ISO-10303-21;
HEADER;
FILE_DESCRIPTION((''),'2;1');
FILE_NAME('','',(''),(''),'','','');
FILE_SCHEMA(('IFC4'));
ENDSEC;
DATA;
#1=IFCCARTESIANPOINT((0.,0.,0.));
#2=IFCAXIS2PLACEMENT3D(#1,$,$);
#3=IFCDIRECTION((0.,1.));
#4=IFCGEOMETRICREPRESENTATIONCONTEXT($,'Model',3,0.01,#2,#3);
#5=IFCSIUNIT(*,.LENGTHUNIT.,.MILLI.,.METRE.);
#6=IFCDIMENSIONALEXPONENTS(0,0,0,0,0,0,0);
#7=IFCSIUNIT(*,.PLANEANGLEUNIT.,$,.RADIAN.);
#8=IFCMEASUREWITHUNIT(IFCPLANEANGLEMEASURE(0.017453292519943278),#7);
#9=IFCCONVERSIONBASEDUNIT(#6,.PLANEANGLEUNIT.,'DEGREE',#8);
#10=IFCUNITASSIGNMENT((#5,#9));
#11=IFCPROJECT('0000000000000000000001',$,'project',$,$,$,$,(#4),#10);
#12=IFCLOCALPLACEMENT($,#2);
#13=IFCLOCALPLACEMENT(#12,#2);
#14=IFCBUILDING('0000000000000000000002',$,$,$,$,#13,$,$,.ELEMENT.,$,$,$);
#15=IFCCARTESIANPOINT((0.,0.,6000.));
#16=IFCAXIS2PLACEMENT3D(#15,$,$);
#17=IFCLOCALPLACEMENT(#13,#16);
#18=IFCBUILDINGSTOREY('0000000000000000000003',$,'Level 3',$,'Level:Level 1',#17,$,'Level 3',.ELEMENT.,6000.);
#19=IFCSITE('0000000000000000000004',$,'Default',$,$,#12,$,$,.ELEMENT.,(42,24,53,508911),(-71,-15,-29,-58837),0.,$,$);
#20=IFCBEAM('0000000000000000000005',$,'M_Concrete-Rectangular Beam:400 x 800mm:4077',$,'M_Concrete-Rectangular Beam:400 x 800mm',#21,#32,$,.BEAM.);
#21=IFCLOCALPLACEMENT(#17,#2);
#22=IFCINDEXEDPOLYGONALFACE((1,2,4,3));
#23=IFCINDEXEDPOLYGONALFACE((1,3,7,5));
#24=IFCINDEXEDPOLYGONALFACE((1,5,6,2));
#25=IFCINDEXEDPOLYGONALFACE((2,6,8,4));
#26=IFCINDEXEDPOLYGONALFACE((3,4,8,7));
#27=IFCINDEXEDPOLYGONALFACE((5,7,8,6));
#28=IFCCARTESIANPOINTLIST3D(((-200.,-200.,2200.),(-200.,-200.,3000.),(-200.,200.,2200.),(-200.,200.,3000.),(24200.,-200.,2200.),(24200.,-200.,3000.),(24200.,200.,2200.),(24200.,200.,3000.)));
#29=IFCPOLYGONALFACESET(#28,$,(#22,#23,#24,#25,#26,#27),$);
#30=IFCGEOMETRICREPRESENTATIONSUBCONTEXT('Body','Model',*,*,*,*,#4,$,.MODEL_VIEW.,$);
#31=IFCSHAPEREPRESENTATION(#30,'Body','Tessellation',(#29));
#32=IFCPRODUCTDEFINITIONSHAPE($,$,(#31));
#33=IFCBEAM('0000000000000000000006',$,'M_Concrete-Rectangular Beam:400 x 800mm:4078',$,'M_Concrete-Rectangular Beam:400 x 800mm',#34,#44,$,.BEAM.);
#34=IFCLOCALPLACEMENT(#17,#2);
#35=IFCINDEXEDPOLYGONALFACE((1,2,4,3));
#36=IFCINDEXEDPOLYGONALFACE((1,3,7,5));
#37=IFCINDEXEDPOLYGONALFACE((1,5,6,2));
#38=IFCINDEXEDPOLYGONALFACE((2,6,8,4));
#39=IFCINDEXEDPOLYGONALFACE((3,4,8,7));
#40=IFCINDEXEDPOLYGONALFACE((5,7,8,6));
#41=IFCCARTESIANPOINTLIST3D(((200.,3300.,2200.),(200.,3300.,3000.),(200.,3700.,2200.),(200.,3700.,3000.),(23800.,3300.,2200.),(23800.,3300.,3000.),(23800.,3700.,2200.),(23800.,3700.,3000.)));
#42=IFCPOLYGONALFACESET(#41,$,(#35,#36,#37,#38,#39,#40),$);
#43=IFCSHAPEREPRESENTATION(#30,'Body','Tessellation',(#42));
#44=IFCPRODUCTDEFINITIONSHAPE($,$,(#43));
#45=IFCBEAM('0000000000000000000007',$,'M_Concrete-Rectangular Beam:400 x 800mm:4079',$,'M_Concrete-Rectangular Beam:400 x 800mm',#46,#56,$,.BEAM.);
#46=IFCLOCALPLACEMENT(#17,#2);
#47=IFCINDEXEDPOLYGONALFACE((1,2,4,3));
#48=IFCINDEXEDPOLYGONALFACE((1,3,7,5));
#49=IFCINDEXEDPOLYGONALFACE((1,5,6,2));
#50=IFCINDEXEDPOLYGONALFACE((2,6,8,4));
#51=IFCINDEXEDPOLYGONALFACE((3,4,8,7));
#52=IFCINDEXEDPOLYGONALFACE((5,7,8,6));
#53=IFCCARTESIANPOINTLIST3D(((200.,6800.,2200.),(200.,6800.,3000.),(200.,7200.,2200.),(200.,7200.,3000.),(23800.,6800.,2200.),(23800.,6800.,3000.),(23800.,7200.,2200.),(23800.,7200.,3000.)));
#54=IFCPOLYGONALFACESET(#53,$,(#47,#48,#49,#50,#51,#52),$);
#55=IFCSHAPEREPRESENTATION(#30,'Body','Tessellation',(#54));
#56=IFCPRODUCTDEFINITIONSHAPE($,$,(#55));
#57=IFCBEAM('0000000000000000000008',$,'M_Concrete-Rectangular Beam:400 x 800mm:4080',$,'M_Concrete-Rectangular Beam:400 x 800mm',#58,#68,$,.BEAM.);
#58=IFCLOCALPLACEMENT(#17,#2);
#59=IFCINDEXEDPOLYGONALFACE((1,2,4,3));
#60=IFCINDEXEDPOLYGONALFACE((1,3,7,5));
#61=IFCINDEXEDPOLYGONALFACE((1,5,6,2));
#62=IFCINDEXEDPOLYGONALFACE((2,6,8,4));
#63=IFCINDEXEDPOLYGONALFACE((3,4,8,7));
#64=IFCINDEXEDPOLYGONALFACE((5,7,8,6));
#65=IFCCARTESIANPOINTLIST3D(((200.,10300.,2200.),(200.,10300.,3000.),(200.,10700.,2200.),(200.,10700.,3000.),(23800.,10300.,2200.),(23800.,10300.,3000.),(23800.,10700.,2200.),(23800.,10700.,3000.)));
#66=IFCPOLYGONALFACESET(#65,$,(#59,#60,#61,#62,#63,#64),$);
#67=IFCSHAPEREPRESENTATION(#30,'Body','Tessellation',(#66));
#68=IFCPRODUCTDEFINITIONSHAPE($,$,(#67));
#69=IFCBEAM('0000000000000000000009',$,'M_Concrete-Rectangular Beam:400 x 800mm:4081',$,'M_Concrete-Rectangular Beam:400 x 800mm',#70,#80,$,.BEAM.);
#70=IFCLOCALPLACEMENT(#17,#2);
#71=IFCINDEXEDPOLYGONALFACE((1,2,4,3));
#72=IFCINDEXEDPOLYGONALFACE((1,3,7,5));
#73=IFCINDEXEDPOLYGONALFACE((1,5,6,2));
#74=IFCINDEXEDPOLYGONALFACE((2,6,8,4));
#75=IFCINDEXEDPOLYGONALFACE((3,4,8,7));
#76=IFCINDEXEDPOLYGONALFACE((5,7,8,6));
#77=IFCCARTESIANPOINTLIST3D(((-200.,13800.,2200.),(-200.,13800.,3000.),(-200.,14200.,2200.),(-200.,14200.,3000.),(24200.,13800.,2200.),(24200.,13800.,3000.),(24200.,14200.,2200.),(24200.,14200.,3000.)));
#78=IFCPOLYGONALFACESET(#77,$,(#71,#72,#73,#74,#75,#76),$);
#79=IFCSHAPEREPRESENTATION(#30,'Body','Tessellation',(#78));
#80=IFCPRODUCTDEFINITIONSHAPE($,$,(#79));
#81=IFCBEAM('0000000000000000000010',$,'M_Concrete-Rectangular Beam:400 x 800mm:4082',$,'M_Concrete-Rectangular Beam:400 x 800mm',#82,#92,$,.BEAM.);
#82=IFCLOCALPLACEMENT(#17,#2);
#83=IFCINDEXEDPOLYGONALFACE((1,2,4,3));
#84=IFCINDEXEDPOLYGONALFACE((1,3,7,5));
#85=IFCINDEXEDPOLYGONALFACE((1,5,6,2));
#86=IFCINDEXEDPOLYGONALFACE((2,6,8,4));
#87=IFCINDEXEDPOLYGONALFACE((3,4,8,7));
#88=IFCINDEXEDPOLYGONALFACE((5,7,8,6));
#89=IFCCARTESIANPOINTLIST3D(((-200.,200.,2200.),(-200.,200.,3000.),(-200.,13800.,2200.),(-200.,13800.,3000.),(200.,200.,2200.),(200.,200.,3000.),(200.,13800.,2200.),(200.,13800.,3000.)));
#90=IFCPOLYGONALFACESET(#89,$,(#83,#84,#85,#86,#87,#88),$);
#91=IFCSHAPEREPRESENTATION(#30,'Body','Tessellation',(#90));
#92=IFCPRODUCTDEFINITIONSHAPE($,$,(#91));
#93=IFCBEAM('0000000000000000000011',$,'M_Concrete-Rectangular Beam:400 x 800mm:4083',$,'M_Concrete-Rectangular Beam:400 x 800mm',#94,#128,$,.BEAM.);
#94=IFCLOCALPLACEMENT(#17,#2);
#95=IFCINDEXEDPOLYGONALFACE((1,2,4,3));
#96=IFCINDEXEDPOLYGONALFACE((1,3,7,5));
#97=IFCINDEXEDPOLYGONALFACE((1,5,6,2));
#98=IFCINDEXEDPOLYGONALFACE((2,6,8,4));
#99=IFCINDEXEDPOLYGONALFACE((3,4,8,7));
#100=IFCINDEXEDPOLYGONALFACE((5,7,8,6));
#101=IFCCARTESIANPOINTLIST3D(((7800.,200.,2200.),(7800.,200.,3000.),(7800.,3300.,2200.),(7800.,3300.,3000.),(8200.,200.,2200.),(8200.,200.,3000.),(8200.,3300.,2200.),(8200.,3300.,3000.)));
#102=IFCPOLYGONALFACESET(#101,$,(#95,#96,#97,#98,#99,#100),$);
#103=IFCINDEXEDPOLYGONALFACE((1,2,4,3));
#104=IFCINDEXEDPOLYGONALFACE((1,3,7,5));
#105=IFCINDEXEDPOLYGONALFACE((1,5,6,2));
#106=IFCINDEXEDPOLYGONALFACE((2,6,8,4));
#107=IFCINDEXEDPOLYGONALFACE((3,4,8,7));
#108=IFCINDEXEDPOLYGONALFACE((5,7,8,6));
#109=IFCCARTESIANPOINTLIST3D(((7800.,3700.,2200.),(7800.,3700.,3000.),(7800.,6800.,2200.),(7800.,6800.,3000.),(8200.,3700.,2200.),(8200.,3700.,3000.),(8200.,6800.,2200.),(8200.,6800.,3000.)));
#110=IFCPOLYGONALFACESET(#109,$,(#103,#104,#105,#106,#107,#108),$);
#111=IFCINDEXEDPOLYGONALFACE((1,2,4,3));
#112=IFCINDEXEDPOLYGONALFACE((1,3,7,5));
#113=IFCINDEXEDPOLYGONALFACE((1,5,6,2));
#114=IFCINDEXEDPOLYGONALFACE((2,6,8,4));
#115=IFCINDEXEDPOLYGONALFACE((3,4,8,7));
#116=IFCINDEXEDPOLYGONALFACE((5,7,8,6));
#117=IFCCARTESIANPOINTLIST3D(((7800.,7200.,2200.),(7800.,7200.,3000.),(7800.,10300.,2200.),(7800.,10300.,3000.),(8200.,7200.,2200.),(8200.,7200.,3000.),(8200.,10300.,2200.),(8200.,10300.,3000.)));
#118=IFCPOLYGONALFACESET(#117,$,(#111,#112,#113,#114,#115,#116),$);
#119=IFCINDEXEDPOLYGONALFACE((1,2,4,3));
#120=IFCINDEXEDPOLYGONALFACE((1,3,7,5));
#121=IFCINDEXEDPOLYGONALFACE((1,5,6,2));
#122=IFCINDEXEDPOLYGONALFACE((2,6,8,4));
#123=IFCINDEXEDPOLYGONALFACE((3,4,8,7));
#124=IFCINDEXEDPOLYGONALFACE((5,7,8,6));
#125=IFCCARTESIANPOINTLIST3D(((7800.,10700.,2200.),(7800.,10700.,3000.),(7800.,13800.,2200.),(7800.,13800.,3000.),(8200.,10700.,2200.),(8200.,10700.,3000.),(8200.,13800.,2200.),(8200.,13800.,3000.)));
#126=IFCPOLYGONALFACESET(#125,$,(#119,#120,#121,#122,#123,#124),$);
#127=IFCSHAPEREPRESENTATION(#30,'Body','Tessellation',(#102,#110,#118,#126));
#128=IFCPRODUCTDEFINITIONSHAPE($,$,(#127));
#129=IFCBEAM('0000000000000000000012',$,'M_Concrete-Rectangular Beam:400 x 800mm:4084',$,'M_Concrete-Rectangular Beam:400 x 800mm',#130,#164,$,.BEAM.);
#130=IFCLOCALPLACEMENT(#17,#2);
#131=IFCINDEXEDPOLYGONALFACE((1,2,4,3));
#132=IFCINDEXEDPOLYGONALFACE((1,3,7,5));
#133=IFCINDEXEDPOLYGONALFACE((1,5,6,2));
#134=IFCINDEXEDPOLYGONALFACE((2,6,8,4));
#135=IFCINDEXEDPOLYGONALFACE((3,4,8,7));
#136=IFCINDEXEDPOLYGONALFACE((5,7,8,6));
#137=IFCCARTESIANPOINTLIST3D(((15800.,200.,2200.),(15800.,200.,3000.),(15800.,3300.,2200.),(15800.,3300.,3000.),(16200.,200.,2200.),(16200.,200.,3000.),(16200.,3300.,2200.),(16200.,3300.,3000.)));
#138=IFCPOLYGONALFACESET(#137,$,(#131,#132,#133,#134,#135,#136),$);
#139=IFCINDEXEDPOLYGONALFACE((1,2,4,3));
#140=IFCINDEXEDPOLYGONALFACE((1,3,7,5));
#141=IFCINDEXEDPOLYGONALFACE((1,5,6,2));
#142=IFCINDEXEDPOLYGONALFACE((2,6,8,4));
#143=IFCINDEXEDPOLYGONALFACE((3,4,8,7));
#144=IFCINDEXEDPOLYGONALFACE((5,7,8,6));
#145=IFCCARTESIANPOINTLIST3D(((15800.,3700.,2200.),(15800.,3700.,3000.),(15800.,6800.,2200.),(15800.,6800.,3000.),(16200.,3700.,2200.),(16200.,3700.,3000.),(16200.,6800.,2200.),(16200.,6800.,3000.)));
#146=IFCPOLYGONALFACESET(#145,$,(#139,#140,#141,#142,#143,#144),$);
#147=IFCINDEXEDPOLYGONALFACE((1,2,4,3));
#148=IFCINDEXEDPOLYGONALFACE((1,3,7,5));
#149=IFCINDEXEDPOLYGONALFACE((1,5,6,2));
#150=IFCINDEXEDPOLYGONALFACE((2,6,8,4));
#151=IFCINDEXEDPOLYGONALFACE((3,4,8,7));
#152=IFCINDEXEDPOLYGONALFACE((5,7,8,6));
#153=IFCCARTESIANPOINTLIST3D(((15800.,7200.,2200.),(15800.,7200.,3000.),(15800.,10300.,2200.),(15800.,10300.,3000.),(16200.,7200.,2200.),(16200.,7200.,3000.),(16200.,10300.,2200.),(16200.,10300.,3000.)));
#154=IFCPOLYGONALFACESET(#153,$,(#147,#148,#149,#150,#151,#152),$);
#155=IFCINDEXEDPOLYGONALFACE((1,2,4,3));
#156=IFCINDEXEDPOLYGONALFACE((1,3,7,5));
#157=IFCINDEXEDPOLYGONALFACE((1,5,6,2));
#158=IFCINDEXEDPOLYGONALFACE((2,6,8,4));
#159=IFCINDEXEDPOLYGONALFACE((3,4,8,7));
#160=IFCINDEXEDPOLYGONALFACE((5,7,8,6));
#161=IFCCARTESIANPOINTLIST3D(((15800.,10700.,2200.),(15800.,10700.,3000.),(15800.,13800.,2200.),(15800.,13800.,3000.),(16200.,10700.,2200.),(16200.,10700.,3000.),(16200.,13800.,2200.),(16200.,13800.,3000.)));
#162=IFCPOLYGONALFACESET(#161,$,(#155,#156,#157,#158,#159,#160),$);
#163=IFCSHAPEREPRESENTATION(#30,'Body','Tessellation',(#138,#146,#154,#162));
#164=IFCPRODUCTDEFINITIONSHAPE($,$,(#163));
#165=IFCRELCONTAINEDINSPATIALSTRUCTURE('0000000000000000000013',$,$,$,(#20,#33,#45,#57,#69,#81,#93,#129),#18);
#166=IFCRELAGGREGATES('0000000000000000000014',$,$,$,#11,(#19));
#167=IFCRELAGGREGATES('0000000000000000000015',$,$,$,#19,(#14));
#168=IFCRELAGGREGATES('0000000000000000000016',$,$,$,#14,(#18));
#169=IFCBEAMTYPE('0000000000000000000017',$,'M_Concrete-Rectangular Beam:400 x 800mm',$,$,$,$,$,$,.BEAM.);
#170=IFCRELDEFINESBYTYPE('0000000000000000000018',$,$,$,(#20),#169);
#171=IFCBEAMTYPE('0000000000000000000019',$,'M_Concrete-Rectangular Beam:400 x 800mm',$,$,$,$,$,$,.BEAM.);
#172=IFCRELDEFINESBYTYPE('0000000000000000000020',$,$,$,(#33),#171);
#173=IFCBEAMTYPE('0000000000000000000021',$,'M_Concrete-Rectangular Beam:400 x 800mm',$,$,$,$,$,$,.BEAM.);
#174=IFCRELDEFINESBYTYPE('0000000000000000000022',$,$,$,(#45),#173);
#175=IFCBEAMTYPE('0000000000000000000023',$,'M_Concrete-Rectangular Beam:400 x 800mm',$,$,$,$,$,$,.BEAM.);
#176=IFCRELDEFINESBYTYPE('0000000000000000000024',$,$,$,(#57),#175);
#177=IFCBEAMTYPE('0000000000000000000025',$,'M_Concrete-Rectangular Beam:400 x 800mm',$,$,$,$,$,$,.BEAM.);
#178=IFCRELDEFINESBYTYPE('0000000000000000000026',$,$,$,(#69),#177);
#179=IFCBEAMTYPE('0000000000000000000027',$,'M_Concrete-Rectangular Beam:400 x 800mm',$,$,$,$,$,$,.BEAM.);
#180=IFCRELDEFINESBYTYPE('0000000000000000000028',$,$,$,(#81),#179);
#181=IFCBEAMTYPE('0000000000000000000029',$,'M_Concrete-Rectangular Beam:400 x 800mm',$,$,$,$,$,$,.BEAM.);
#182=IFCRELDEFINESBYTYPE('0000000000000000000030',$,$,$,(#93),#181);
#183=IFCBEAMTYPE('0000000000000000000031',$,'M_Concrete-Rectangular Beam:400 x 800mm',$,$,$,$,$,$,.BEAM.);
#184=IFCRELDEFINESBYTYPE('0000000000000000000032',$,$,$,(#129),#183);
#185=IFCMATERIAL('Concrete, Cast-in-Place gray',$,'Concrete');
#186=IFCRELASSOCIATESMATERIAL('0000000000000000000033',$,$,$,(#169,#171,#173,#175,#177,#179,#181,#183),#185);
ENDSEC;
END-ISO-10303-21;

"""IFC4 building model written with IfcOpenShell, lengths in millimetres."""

from ifc_helpers import new_model, entity, si_unit, converted_unit, direction, frame, frame_2d, origin, origin_2d_with_axis, place, context, subcontext, project, spatial, rectangle, extrude, source, transform, mapped, material, material_profile, profile_set, type_object, type_shapes, element, save


model = new_model("IFC4")

# Units and contexts
model_context = context("Model", 3, precision=0.01, world=origin(), true_north=direction((0.0, 1.0)))
body_context = subcontext(model_context, "Body", "Model", "MODEL_VIEW")
ifc_project = project(units=[si_unit("LENGTHUNIT", "METRE", prefix="MILLI"), converted_unit("PLANEANGLEUNIT", "DEGREE", entity("IfcPlaneAngleMeasure", 0.017453292519943278), si_unit("PLANEANGLEUNIT", "RADIAN"), dimensions=[0, 0, 0, 0, 0, 0, 0])], contexts=[model_context])

# Site, building, storey
site_placement = place(None, origin())
site = spatial("IfcSite", under=ifc_project, at=site_placement, Name="Default", CompositionType="ELEMENT", RefLatitude=(42, 24, 53, 508911), RefLongitude=(-71, -15, -29, -58837), RefElevation=0.0)
building_placement = place(site_placement, origin())
building = spatial("IfcBuilding", under=site, at=building_placement, CompositionType="ELEMENT")
storey_placement = place(building_placement, frame((0.0, 0.0, 6000.0)))
storey = spatial("IfcBuildingStorey", under=building, at=storey_placement, Name="Level 3", ObjectType="Level:Level 1", LongName="Level 3", CompositionType="ELEMENT", Elevation=6000.0)

# Beams
ifc_material_1 = material(Name="Concrete, Cast-in-Place gray", Category="Concrete")
ifc_material_profile = material_profile(ifc_material_1, rectangle(XDim=800.0, YDim=400.0, at=origin_2d_with_axis()), Name="400 x 800mm")
ifc_profile_set = profile_set([ifc_material_profile], Name="400 x 800mm")
beam_type_1 = type_object("IfcBeamType", Name="M_Concrete-Rectangular Beam:400 x 800mm", PredefinedType="BEAM", material=ifc_profile_set)
shared_shape_1 = source(origin(), body_context, "Body", "SweptSolid", [
    extrude(rectangle(XDim=800.0, YDim=400.0, at=origin_2d_with_axis()), frame((-200.0, 0.0, 8600.0), z_axis=(1.0, 0.0, 0.0), x_axis=(0.0, 0.0, -1.0)), (0.0, 0.0, 1.0), 24400.0),
])
type_shapes(beam_type_1, [shared_shape_1])
beam_1_placement = place(storey_placement, frame((0.0, 0.0, -6000.0)))
element("IfcBeam", 1, at=beam_1_placement, inside=storey, type_object=beam_type_1, Name="M_Concrete-Rectangular Beam:400 x 800mm:4077", ObjectType="M_Concrete-Rectangular Beam:400 x 800mm", PredefinedType="BEAM", context=body_context, shape_type="MappedRepresentation", body=[
    mapped(shared_shape_1, transform((0.0, 0.0, 0.0), scale=1.0)),
])
beam_type_2 = type_object("IfcBeamType", Name="M_Concrete-Rectangular Beam:400 x 800mm", PredefinedType="BEAM", material=ifc_profile_set)
shared_shape_2 = source(origin(), body_context, "Body", "SweptSolid", [
    extrude(rectangle(XDim=800.0, YDim=400.0, at=origin_2d_with_axis()), frame((200.0, 3500.0, 8600.0), z_axis=(1.0, 0.0, 0.0), x_axis=(0.0, 0.0, -1.0)), (0.0, 0.0, 1.0), 23600.0),
])
type_shapes(beam_type_2, [shared_shape_2])
beam_2_placement = place(storey_placement, frame((0.0, 0.0, -6000.0)))
element("IfcBeam", 2, at=beam_2_placement, inside=storey, type_object=beam_type_2, Name="M_Concrete-Rectangular Beam:400 x 800mm:4078", ObjectType="M_Concrete-Rectangular Beam:400 x 800mm", PredefinedType="BEAM", context=body_context, shape_type="MappedRepresentation", body=[
    mapped(shared_shape_2, transform((0.0, 0.0, 0.0), scale=1.0)),
])
beam_type_3 = type_object("IfcBeamType", Name="M_Concrete-Rectangular Beam:400 x 800mm", PredefinedType="BEAM", material=ifc_profile_set)
shared_shape_3 = source(origin(), body_context, "Body", "SweptSolid", [
    extrude(rectangle(XDim=800.0, YDim=400.0, at=frame_2d((0.0, 0.0), x_axis=(1.0, 0.0))), frame((200.0, 7000.0, 8600.0), z_axis=(1.0, 0.0, 0.0), x_axis=(0.0, 0.0, -1.0)), (0.0, 0.0, 1.0), 23600.0),
])
type_shapes(beam_type_3, [shared_shape_3])
beam_3_placement = place(storey_placement, frame((0.0, 0.0, -6000.0)))
element("IfcBeam", 3, at=beam_3_placement, inside=storey, type_object=beam_type_3, Name="M_Concrete-Rectangular Beam:400 x 800mm:4079", ObjectType="M_Concrete-Rectangular Beam:400 x 800mm", PredefinedType="BEAM", context=body_context, shape_type="MappedRepresentation", body=[
    mapped(shared_shape_3, transform((0.0, 0.0, 0.0), scale=1.0)),
])
beam_type_4 = type_object("IfcBeamType", Name="M_Concrete-Rectangular Beam:400 x 800mm", PredefinedType="BEAM", material=ifc_profile_set)
shared_shape_4 = source(origin(), body_context, "Body", "SweptSolid", [
    extrude(rectangle(XDim=800.0, YDim=400.0, at=frame_2d((0.0, 0.0), x_axis=(1.0, 0.0))), frame((200.0, 10500.0, 8600.0), z_axis=(1.0, 0.0, 0.0), x_axis=(0.0, 0.0, -1.0)), (0.0, 0.0, 1.0), 23600.0),
])
type_shapes(beam_type_4, [shared_shape_4])
beam_4_placement = place(storey_placement, frame((0.0, 0.0, -6000.0)))
element("IfcBeam", 4, at=beam_4_placement, inside=storey, type_object=beam_type_4, Name="M_Concrete-Rectangular Beam:400 x 800mm:4080", ObjectType="M_Concrete-Rectangular Beam:400 x 800mm", PredefinedType="BEAM", context=body_context, shape_type="MappedRepresentation", body=[
    mapped(shared_shape_4, transform((0.0, 0.0, 0.0), scale=1.0)),
])
beam_type_5 = type_object("IfcBeamType", Name="M_Concrete-Rectangular Beam:400 x 800mm", PredefinedType="BEAM", material=ifc_profile_set)
shared_shape_5 = source(origin(), body_context, "Body", "SweptSolid", [
    extrude(rectangle(XDim=800.0, YDim=400.0, at=origin_2d_with_axis()), frame((-200.0, 14000.0, 8600.0), z_axis=(1.0, 0.0, 0.0), x_axis=(0.0, 0.0, -1.0)), (0.0, 0.0, 1.0), 24400.0),
])
type_shapes(beam_type_5, [shared_shape_5])
beam_5_placement = place(storey_placement, frame((0.0, 0.0, -6000.0)))
element("IfcBeam", 5, at=beam_5_placement, inside=storey, type_object=beam_type_5, Name="M_Concrete-Rectangular Beam:400 x 800mm:4081", ObjectType="M_Concrete-Rectangular Beam:400 x 800mm", PredefinedType="BEAM", context=body_context, shape_type="MappedRepresentation", body=[
    mapped(shared_shape_5, transform((0.0, 0.0, 0.0), scale=1.0)),
])
beam_type_6 = type_object("IfcBeamType", Name="M_Concrete-Rectangular Beam:400 x 800mm", PredefinedType="BEAM", material=ifc_profile_set)
shared_shape_6 = source(origin(), body_context, "Body", "SweptSolid", [
    extrude(rectangle(XDim=800.0, YDim=400.0, at=frame_2d((0.0, 0.0), x_axis=(0.0, 1.0))), frame((0.0, 200.0, 8600.0), z_axis=(0.0, 1.0, 0.0), x_axis=(-1.0, 0.0, 0.0)), (0.0, 0.0, 1.0), 13600.0),
])
type_shapes(beam_type_6, [shared_shape_6])
beam_6_placement = place(storey_placement, frame((0.0, 0.0, -6000.0)))
element("IfcBeam", 6, at=beam_6_placement, inside=storey, type_object=beam_type_6, Name="M_Concrete-Rectangular Beam:400 x 800mm:4082", ObjectType="M_Concrete-Rectangular Beam:400 x 800mm", PredefinedType="BEAM", context=body_context, shape_type="MappedRepresentation", body=[
    mapped(shared_shape_6, transform((0.0, 0.0, 0.0), scale=1.0)),
])
beam_type_7 = type_object("IfcBeamType", Name="M_Concrete-Rectangular Beam:400 x 800mm", PredefinedType="BEAM", material=ifc_profile_set)
shared_shape_7 = source(origin(), body_context, "Body", "SweptSolid", [
    extrude(rectangle(XDim=800.0, YDim=400.0, at=frame_2d((0.0, 0.0), x_axis=(0.0, 1.0))), frame((8000.0, 200.0, 8600.0), z_axis=(0.0, 1.0, 0.0), x_axis=(-1.0, 0.0, 0.0)), (0.0, 0.0, 1.0), 3100.0),
    extrude(rectangle(XDim=800.0, YDim=400.0, at=frame_2d((0.0, 0.0), x_axis=(0.0, 1.0))), frame((8000.0, 3700.0, 8600.0), z_axis=(0.0, 1.0, 0.0), x_axis=(-1.0, 0.0, 0.0)), (0.0, 0.0, 1.0), 3100.0),
    extrude(rectangle(XDim=800.0, YDim=400.0, at=frame_2d((0.0, 0.0), x_axis=(0.0, 1.0))), frame((8000.0, 7200.0, 8600.0), z_axis=(0.0, 1.0, 0.0), x_axis=(-1.0, 0.0, 0.0)), (0.0, 0.0, 1.0), 3100.0),
    extrude(rectangle(XDim=800.0, YDim=400.0, at=frame_2d((0.0, 0.0), x_axis=(0.0, 1.0))), frame((8000.0, 10700.0, 8600.0), z_axis=(0.0, 1.0, 0.0), x_axis=(-1.0, 0.0, 0.0)), (0.0, 0.0, 1.0), 3100.0),
])
type_shapes(beam_type_7, [shared_shape_7])
beam_7_placement = place(storey_placement, frame((0.0, 0.0, -6000.0)))
element("IfcBeam", 7, at=beam_7_placement, inside=storey, type_object=beam_type_7, Name="M_Concrete-Rectangular Beam:400 x 800mm:4083", ObjectType="M_Concrete-Rectangular Beam:400 x 800mm", PredefinedType="BEAM", context=body_context, shape_type="MappedRepresentation", body=[
    mapped(shared_shape_7, transform((0.0, 0.0, 0.0), scale=1.0)),
])
beam_type_8 = type_object("IfcBeamType", Name="M_Concrete-Rectangular Beam:400 x 800mm", PredefinedType="BEAM", material=ifc_profile_set)
shared_shape_8 = source(origin(), body_context, "Body", "SweptSolid", [
    extrude(rectangle(XDim=800.0, YDim=400.0, at=frame_2d((0.0, 0.0), x_axis=(0.0, 1.0))), frame((16000.0, 200.0, 8600.0), z_axis=(0.0, 1.0, 0.0), x_axis=(-1.0, 0.0, 0.0)), (0.0, 0.0, 1.0), 3100.0),
    extrude(rectangle(XDim=800.0, YDim=400.0, at=frame_2d((0.0, 0.0), x_axis=(0.0, 1.0))), frame((16000.0, 3700.0, 8600.0), z_axis=(0.0, 1.0, 0.0), x_axis=(-1.0, 0.0, 0.0)), (0.0, 0.0, 1.0), 3100.0),
    extrude(rectangle(XDim=800.0, YDim=400.0, at=frame_2d((0.0, 0.0), x_axis=(0.0, 1.0))), frame((16000.0, 7200.0, 8600.0), z_axis=(0.0, 1.0, 0.0), x_axis=(-1.0, 0.0, 0.0)), (0.0, 0.0, 1.0), 3100.0),
    extrude(rectangle(XDim=800.0, YDim=400.0, at=frame_2d((0.0, 0.0), x_axis=(0.0, 1.0))), frame((16000.0, 10700.0, 8600.0), z_axis=(0.0, 1.0, 0.0), x_axis=(-1.0, 0.0, 0.0)), (0.0, 0.0, 1.0), 3100.0),
])
type_shapes(beam_type_8, [shared_shape_8])
beam_8_placement = place(storey_placement, frame((0.0, 0.0, -6000.0)))
element("IfcBeam", 8, at=beam_8_placement, inside=storey, type_object=beam_type_8, Name="M_Concrete-Rectangular Beam:400 x 800mm:4084", ObjectType="M_Concrete-Rectangular Beam:400 x 800mm", PredefinedType="BEAM", context=body_context, shape_type="MappedRepresentation", body=[
    mapped(shared_shape_8, transform((0.0, 0.0, 0.0), scale=1.0)),
])

save(model, "model.ifc")
